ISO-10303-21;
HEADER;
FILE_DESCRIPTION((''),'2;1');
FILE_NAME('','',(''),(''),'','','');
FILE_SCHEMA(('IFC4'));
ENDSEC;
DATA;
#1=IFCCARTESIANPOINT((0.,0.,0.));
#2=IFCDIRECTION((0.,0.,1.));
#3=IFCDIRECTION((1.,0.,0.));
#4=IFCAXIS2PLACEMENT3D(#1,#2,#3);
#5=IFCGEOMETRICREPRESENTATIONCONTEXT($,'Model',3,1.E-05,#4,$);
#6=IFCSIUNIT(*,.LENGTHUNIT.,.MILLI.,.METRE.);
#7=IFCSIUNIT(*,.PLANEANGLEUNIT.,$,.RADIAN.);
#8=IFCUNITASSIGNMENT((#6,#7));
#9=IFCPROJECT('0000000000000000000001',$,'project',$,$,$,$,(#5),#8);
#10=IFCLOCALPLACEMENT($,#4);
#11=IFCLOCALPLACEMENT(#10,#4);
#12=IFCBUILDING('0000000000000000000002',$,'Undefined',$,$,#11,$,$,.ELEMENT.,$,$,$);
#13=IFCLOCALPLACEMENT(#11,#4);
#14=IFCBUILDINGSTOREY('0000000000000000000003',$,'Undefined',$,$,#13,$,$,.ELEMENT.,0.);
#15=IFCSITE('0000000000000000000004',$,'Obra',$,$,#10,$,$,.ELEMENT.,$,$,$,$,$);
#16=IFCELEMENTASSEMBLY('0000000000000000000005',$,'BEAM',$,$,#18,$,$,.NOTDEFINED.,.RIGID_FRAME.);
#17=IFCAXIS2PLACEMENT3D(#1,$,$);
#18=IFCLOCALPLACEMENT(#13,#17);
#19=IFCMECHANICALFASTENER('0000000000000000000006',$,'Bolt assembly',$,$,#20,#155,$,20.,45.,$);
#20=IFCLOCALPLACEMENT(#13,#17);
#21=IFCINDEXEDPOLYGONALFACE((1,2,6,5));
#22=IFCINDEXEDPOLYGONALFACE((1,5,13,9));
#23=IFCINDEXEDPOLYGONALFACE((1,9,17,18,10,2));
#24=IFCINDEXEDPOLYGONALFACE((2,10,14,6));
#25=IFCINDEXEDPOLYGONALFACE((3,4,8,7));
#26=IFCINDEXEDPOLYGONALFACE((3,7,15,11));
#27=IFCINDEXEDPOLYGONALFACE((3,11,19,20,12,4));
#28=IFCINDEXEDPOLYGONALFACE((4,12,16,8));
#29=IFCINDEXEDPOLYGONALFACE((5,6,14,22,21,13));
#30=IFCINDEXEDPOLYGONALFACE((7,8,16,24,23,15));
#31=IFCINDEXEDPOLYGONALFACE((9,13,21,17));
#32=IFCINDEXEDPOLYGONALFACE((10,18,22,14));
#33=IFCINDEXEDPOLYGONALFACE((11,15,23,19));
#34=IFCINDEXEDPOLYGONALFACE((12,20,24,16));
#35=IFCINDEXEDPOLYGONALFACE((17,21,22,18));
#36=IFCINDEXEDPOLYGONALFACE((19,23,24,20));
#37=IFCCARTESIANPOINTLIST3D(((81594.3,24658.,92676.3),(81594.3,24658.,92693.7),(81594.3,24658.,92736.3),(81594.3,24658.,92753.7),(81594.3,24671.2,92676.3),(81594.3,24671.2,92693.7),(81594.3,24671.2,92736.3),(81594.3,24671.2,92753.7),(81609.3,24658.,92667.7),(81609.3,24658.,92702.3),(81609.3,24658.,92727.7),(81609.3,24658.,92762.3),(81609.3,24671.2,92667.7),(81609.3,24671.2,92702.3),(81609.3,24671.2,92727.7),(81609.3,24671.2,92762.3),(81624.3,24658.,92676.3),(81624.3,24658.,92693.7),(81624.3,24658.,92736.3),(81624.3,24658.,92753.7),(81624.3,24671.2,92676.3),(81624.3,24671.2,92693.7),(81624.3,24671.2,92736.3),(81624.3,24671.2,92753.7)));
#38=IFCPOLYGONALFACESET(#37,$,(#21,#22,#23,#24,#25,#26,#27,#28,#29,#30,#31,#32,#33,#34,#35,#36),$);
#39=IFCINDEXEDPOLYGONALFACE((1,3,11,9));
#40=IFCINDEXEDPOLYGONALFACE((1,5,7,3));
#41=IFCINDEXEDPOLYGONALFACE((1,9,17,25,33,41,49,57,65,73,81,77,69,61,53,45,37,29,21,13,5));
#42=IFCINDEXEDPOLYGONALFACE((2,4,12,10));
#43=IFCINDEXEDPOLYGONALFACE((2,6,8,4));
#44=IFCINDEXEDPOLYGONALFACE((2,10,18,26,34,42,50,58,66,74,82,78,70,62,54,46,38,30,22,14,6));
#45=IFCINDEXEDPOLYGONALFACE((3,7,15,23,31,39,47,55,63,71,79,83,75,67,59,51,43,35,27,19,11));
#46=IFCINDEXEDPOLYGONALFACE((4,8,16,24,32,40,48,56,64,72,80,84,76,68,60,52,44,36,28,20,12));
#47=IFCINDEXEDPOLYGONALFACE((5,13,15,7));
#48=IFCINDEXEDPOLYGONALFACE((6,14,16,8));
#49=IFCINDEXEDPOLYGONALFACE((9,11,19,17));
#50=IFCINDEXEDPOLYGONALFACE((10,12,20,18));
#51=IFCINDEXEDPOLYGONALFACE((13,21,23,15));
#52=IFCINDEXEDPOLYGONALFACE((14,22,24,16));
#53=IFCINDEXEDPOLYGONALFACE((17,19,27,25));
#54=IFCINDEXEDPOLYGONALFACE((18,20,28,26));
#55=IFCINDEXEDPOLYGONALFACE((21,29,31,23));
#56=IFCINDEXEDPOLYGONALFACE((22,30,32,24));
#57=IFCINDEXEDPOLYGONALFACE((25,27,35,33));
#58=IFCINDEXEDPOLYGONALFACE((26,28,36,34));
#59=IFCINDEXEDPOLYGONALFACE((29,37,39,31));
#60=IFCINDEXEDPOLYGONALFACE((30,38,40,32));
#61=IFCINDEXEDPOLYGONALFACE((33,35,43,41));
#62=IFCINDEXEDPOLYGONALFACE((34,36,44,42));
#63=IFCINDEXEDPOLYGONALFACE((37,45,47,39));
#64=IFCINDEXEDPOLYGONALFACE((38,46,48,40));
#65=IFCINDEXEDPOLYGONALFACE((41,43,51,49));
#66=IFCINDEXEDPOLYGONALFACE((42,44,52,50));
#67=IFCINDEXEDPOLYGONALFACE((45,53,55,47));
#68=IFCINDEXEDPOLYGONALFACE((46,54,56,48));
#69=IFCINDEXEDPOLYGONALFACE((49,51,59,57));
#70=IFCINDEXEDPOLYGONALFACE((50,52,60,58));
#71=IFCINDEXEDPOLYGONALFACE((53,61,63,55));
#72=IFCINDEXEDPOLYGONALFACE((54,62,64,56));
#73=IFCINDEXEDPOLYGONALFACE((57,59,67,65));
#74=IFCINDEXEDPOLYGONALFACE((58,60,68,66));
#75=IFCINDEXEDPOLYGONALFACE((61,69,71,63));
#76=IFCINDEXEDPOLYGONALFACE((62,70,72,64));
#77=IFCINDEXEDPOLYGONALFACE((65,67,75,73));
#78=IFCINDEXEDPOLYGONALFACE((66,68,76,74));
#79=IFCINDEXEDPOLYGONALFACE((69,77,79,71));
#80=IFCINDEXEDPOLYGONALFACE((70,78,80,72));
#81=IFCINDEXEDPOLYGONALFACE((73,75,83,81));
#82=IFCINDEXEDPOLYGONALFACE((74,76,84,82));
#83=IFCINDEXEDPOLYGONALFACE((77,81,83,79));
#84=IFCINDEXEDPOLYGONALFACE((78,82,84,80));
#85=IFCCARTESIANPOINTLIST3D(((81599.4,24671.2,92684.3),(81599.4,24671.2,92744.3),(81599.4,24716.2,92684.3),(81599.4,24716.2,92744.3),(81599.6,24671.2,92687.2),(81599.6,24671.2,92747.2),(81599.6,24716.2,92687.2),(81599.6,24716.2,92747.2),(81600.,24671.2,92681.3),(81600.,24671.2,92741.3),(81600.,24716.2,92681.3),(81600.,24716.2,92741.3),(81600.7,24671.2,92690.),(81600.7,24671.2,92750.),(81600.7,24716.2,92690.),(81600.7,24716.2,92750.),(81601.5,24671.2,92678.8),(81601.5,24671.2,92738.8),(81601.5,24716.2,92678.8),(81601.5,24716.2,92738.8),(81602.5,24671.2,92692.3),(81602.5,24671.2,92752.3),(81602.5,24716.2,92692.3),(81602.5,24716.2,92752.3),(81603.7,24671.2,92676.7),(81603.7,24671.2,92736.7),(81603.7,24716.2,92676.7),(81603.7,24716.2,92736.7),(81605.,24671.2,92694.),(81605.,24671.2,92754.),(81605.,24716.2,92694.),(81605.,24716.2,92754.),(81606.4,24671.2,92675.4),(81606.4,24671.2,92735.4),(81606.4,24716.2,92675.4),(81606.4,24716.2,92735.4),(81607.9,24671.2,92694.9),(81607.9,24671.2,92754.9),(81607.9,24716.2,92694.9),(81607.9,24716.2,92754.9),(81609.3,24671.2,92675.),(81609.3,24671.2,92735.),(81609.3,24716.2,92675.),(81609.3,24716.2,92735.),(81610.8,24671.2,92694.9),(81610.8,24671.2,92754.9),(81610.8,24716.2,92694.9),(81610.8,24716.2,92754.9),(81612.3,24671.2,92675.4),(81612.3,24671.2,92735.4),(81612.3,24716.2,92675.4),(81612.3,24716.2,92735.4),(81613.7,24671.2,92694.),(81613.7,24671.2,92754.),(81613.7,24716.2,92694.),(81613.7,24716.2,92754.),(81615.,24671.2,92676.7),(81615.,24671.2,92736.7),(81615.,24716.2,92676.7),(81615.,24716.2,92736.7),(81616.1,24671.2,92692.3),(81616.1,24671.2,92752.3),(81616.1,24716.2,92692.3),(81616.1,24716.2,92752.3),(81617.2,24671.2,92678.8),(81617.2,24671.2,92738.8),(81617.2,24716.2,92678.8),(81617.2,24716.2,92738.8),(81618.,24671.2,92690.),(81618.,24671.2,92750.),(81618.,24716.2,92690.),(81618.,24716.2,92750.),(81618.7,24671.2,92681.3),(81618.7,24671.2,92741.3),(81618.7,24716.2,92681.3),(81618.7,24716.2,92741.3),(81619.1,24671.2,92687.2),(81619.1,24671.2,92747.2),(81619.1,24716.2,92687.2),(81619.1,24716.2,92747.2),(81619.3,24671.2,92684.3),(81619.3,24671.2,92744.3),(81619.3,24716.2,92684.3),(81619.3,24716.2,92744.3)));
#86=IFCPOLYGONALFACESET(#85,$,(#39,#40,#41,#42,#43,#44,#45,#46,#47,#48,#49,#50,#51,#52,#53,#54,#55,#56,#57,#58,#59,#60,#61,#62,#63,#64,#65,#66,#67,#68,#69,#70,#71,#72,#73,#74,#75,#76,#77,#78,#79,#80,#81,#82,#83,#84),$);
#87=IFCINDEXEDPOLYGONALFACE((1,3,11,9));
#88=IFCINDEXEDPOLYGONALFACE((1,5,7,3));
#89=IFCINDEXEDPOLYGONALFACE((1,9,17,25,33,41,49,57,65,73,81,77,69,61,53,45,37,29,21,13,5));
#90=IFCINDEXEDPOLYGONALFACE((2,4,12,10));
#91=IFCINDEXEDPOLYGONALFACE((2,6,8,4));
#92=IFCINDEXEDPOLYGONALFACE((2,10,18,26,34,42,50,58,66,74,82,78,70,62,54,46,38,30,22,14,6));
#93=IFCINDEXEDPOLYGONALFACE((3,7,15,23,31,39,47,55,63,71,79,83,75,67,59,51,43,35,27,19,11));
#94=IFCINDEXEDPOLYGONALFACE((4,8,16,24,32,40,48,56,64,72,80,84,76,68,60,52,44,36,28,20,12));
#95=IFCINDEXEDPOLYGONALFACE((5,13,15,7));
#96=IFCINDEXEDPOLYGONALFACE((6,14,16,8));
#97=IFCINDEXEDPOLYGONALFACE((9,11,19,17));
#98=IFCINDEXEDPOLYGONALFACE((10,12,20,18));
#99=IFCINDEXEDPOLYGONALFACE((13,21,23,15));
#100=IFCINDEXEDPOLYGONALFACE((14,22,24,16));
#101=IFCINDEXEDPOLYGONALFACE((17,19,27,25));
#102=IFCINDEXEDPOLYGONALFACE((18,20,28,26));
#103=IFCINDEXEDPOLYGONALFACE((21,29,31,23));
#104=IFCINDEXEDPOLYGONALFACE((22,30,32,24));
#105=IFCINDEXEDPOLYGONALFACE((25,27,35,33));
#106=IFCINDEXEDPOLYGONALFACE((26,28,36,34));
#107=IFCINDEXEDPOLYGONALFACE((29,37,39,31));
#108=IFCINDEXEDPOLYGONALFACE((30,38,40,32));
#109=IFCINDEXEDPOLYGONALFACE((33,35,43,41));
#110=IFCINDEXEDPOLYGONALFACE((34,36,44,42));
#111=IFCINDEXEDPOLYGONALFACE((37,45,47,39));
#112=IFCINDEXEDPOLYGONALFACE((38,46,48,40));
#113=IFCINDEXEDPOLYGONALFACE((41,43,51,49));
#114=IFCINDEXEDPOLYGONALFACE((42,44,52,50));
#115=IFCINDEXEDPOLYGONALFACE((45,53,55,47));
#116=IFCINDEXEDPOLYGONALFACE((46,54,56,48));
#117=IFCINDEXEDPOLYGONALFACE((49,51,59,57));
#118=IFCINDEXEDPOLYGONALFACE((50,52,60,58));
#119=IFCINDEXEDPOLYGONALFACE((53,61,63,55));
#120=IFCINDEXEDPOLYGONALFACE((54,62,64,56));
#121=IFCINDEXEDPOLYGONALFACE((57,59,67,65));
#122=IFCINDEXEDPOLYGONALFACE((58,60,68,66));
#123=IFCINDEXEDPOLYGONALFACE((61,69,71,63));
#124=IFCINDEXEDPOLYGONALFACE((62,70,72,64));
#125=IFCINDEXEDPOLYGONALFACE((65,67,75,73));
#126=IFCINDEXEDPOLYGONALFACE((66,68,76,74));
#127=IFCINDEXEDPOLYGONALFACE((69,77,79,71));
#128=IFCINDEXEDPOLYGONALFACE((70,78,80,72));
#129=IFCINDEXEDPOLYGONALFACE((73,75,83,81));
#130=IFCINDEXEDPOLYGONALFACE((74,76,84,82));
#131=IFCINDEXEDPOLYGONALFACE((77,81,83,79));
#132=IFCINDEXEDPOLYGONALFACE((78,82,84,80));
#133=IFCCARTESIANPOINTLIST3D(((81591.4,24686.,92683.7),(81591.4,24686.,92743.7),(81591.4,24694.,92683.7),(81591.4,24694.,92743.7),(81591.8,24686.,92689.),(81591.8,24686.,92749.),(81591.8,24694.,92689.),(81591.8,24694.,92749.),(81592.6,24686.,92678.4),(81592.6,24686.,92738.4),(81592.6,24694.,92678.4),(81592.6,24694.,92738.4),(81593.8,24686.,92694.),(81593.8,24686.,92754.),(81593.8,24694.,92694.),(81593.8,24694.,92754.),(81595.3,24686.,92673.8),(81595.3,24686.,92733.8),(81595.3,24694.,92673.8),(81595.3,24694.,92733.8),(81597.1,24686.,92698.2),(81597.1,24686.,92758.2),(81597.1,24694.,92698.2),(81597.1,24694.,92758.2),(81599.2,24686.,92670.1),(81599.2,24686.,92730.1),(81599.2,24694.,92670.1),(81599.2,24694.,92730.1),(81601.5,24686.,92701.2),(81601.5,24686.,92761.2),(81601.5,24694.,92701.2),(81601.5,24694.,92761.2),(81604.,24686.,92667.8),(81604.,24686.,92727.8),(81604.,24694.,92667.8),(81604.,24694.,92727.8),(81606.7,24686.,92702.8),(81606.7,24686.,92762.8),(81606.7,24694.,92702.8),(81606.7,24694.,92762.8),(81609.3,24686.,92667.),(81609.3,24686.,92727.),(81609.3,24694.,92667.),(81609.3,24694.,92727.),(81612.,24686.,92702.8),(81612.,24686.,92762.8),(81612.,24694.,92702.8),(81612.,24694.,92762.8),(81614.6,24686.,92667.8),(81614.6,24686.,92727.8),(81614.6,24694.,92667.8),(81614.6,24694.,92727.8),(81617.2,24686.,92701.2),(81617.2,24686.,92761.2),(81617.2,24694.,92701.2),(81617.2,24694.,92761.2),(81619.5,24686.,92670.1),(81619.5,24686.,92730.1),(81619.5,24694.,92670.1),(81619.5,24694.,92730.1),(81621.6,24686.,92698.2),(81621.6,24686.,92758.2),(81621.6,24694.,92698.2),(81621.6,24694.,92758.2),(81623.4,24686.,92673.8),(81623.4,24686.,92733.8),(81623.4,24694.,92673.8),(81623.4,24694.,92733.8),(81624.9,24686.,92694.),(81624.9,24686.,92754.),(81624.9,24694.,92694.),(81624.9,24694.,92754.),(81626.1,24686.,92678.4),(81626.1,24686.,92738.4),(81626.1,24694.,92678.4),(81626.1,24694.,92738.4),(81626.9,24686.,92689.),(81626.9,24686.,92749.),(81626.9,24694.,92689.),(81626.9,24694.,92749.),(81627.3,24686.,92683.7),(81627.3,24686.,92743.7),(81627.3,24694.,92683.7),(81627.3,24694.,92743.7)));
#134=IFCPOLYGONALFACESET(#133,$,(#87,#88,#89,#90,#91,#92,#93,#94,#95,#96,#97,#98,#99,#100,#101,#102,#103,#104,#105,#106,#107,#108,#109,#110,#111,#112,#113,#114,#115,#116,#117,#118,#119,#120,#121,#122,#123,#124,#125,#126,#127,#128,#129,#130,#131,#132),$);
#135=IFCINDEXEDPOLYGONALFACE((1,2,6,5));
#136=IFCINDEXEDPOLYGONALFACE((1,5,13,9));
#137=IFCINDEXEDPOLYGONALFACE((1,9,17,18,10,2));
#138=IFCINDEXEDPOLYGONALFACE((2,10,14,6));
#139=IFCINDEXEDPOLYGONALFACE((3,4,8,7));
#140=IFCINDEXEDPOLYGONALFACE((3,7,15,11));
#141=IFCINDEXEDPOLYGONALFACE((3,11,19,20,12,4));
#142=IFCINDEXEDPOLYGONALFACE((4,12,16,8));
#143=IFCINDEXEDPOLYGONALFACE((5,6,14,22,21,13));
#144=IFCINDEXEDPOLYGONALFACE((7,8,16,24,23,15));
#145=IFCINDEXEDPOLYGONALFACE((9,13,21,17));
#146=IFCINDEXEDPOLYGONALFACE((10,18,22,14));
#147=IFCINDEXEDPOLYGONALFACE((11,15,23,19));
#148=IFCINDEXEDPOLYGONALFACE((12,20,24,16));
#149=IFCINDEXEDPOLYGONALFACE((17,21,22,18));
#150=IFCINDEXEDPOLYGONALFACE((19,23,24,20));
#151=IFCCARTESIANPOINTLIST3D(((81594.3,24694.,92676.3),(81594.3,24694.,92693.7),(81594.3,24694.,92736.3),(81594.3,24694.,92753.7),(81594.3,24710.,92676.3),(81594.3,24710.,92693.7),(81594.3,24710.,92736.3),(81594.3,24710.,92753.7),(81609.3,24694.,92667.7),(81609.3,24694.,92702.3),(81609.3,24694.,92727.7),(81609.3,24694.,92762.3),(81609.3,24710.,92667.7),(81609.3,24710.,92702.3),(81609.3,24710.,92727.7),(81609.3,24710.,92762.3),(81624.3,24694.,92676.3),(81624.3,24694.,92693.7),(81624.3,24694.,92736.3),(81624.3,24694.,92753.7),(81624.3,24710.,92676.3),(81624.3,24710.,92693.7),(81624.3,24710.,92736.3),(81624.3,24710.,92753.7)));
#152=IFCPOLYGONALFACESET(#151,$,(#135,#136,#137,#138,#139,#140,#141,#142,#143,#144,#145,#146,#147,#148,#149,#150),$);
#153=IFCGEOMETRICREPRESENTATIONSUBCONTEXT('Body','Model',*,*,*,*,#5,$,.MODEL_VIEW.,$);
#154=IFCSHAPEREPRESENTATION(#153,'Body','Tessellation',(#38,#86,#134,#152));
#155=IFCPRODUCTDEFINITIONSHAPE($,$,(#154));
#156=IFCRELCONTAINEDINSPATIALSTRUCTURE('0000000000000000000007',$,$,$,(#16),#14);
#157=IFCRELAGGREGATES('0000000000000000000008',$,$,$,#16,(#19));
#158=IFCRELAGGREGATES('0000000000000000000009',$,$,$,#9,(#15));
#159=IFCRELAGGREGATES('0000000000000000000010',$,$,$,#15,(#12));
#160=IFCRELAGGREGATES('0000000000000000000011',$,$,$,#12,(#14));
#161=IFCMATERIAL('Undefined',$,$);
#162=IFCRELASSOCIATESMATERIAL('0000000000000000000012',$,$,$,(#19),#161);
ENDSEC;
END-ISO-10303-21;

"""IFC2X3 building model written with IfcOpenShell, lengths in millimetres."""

from ifc_helpers import new_model, si_unit, frame, origin_with_axes, origin_2d_with_axis, place, context, subcontext, project, spatial, polyline, circle, outline, extrude, source, transform, mapped, material, element, aggregate, save


model = new_model("IFC2X3")

# Units and contexts
model_context = context("Model", 3, precision=1e-05, world=origin_with_axes())
body_context = subcontext(model_context, "Body", "Model", "MODEL_VIEW")
ifc_project = project(units=[si_unit("LENGTHUNIT", "METRE", prefix="MILLI"), si_unit("PLANEANGLEUNIT", "RADIAN")], contexts=[model_context])

# Site, building, storey
site_placement = place(None, origin_with_axes())
site = spatial("IfcSite", under=ifc_project, at=site_placement, Name="Obra", CompositionType="ELEMENT")
building_placement = place(site_placement, origin_with_axes())
building = spatial("IfcBuilding", under=site, at=building_placement, Name="Undefined", CompositionType="ELEMENT")
storey_placement = place(building_placement, origin_with_axes())
storey = spatial("IfcBuildingStorey", under=building, at=storey_placement, Name="Undefined", CompositionType="ELEMENT", Elevation=0.0)

# Shared definitions
ifc_material_1 = material(Name="Undefined")

# Element assembly, mechanical fastener
assembly_1_placement = place(storey_placement, origin_with_axes())
assembly_1 = element("IfcElementAssembly", 1, at=assembly_1_placement, inside=storey, Name="BEAM", AssemblyPlace="NOTDEFINED", PredefinedType="RIGID_FRAME")
shared_shape_1 = source(origin_with_axes(), body_context, "Body", "SweptSolid", [
    extrude(outline(polyline([(17.3, 0.0), (8.7, 15.0), (-8.7, 15.0), (-17.3, 0.0), (-8.7, -15.0), (8.7, -15.0), (17.3, 0.0)])), frame((0.0, -24.7, 0.0), z_axis=(0.0, 1.0, 0.0), x_axis=(1.0, 0.0, 0.0)), (0.0, 0.0, 1.0), 13.2),
    extrude(circle(Radius=10.0, at=origin_2d_with_axis()), frame((0.0, -11.5, 0.0), z_axis=(0.0, 1.0, 0.0), x_axis=(1.0, 0.0, 0.0)), (0.0, 0.0, 1.0), 45.0),
    extrude(circle(Radius=18.0, at=origin_2d_with_axis()), frame((0.0, 3.3, 0.0), z_axis=(0.0, 1.0, 0.0), x_axis=(1.0, 0.0, 0.0)), (0.0, 0.0, 1.0), 8.0),
    extrude(outline(polyline([(17.3, 0.0), (8.7, 15.0), (-8.7, 15.0), (-17.3, 0.0), (-8.7, -15.0), (8.7, -15.0), (17.3, 0.0)])), frame((0.0, 11.3, 0.0), z_axis=(0.0, 1.0, 0.0), x_axis=(1.0, 0.0, 0.0)), (0.0, 0.0, 1.0), 16.0),
])
mechanical_fastener_1_placement = place(assembly_1_placement, frame((81569.3, 24682.7, 92850.0), z_axis=(1.0, 0.000001, 0.0), x_axis=(0.0, 0.0, -1.0)))
mechanical_fastener_1 = element("IfcMechanicalFastener", 2, at=mechanical_fastener_1_placement, material=ifc_material_1, Name="Bolt assembly", NominalDiameter=20.0, NominalLength=45.0, context=body_context, shape_type="MappedRepresentation", body=[
    mapped(shared_shape_1, transform((105.0, 0.0, 40.0))),
    mapped(shared_shape_1, transform((165.0, 0.0, 40.0))),
])
aggregate(assembly_1, [mechanical_fastener_1])

save(model, "model.ifc")
